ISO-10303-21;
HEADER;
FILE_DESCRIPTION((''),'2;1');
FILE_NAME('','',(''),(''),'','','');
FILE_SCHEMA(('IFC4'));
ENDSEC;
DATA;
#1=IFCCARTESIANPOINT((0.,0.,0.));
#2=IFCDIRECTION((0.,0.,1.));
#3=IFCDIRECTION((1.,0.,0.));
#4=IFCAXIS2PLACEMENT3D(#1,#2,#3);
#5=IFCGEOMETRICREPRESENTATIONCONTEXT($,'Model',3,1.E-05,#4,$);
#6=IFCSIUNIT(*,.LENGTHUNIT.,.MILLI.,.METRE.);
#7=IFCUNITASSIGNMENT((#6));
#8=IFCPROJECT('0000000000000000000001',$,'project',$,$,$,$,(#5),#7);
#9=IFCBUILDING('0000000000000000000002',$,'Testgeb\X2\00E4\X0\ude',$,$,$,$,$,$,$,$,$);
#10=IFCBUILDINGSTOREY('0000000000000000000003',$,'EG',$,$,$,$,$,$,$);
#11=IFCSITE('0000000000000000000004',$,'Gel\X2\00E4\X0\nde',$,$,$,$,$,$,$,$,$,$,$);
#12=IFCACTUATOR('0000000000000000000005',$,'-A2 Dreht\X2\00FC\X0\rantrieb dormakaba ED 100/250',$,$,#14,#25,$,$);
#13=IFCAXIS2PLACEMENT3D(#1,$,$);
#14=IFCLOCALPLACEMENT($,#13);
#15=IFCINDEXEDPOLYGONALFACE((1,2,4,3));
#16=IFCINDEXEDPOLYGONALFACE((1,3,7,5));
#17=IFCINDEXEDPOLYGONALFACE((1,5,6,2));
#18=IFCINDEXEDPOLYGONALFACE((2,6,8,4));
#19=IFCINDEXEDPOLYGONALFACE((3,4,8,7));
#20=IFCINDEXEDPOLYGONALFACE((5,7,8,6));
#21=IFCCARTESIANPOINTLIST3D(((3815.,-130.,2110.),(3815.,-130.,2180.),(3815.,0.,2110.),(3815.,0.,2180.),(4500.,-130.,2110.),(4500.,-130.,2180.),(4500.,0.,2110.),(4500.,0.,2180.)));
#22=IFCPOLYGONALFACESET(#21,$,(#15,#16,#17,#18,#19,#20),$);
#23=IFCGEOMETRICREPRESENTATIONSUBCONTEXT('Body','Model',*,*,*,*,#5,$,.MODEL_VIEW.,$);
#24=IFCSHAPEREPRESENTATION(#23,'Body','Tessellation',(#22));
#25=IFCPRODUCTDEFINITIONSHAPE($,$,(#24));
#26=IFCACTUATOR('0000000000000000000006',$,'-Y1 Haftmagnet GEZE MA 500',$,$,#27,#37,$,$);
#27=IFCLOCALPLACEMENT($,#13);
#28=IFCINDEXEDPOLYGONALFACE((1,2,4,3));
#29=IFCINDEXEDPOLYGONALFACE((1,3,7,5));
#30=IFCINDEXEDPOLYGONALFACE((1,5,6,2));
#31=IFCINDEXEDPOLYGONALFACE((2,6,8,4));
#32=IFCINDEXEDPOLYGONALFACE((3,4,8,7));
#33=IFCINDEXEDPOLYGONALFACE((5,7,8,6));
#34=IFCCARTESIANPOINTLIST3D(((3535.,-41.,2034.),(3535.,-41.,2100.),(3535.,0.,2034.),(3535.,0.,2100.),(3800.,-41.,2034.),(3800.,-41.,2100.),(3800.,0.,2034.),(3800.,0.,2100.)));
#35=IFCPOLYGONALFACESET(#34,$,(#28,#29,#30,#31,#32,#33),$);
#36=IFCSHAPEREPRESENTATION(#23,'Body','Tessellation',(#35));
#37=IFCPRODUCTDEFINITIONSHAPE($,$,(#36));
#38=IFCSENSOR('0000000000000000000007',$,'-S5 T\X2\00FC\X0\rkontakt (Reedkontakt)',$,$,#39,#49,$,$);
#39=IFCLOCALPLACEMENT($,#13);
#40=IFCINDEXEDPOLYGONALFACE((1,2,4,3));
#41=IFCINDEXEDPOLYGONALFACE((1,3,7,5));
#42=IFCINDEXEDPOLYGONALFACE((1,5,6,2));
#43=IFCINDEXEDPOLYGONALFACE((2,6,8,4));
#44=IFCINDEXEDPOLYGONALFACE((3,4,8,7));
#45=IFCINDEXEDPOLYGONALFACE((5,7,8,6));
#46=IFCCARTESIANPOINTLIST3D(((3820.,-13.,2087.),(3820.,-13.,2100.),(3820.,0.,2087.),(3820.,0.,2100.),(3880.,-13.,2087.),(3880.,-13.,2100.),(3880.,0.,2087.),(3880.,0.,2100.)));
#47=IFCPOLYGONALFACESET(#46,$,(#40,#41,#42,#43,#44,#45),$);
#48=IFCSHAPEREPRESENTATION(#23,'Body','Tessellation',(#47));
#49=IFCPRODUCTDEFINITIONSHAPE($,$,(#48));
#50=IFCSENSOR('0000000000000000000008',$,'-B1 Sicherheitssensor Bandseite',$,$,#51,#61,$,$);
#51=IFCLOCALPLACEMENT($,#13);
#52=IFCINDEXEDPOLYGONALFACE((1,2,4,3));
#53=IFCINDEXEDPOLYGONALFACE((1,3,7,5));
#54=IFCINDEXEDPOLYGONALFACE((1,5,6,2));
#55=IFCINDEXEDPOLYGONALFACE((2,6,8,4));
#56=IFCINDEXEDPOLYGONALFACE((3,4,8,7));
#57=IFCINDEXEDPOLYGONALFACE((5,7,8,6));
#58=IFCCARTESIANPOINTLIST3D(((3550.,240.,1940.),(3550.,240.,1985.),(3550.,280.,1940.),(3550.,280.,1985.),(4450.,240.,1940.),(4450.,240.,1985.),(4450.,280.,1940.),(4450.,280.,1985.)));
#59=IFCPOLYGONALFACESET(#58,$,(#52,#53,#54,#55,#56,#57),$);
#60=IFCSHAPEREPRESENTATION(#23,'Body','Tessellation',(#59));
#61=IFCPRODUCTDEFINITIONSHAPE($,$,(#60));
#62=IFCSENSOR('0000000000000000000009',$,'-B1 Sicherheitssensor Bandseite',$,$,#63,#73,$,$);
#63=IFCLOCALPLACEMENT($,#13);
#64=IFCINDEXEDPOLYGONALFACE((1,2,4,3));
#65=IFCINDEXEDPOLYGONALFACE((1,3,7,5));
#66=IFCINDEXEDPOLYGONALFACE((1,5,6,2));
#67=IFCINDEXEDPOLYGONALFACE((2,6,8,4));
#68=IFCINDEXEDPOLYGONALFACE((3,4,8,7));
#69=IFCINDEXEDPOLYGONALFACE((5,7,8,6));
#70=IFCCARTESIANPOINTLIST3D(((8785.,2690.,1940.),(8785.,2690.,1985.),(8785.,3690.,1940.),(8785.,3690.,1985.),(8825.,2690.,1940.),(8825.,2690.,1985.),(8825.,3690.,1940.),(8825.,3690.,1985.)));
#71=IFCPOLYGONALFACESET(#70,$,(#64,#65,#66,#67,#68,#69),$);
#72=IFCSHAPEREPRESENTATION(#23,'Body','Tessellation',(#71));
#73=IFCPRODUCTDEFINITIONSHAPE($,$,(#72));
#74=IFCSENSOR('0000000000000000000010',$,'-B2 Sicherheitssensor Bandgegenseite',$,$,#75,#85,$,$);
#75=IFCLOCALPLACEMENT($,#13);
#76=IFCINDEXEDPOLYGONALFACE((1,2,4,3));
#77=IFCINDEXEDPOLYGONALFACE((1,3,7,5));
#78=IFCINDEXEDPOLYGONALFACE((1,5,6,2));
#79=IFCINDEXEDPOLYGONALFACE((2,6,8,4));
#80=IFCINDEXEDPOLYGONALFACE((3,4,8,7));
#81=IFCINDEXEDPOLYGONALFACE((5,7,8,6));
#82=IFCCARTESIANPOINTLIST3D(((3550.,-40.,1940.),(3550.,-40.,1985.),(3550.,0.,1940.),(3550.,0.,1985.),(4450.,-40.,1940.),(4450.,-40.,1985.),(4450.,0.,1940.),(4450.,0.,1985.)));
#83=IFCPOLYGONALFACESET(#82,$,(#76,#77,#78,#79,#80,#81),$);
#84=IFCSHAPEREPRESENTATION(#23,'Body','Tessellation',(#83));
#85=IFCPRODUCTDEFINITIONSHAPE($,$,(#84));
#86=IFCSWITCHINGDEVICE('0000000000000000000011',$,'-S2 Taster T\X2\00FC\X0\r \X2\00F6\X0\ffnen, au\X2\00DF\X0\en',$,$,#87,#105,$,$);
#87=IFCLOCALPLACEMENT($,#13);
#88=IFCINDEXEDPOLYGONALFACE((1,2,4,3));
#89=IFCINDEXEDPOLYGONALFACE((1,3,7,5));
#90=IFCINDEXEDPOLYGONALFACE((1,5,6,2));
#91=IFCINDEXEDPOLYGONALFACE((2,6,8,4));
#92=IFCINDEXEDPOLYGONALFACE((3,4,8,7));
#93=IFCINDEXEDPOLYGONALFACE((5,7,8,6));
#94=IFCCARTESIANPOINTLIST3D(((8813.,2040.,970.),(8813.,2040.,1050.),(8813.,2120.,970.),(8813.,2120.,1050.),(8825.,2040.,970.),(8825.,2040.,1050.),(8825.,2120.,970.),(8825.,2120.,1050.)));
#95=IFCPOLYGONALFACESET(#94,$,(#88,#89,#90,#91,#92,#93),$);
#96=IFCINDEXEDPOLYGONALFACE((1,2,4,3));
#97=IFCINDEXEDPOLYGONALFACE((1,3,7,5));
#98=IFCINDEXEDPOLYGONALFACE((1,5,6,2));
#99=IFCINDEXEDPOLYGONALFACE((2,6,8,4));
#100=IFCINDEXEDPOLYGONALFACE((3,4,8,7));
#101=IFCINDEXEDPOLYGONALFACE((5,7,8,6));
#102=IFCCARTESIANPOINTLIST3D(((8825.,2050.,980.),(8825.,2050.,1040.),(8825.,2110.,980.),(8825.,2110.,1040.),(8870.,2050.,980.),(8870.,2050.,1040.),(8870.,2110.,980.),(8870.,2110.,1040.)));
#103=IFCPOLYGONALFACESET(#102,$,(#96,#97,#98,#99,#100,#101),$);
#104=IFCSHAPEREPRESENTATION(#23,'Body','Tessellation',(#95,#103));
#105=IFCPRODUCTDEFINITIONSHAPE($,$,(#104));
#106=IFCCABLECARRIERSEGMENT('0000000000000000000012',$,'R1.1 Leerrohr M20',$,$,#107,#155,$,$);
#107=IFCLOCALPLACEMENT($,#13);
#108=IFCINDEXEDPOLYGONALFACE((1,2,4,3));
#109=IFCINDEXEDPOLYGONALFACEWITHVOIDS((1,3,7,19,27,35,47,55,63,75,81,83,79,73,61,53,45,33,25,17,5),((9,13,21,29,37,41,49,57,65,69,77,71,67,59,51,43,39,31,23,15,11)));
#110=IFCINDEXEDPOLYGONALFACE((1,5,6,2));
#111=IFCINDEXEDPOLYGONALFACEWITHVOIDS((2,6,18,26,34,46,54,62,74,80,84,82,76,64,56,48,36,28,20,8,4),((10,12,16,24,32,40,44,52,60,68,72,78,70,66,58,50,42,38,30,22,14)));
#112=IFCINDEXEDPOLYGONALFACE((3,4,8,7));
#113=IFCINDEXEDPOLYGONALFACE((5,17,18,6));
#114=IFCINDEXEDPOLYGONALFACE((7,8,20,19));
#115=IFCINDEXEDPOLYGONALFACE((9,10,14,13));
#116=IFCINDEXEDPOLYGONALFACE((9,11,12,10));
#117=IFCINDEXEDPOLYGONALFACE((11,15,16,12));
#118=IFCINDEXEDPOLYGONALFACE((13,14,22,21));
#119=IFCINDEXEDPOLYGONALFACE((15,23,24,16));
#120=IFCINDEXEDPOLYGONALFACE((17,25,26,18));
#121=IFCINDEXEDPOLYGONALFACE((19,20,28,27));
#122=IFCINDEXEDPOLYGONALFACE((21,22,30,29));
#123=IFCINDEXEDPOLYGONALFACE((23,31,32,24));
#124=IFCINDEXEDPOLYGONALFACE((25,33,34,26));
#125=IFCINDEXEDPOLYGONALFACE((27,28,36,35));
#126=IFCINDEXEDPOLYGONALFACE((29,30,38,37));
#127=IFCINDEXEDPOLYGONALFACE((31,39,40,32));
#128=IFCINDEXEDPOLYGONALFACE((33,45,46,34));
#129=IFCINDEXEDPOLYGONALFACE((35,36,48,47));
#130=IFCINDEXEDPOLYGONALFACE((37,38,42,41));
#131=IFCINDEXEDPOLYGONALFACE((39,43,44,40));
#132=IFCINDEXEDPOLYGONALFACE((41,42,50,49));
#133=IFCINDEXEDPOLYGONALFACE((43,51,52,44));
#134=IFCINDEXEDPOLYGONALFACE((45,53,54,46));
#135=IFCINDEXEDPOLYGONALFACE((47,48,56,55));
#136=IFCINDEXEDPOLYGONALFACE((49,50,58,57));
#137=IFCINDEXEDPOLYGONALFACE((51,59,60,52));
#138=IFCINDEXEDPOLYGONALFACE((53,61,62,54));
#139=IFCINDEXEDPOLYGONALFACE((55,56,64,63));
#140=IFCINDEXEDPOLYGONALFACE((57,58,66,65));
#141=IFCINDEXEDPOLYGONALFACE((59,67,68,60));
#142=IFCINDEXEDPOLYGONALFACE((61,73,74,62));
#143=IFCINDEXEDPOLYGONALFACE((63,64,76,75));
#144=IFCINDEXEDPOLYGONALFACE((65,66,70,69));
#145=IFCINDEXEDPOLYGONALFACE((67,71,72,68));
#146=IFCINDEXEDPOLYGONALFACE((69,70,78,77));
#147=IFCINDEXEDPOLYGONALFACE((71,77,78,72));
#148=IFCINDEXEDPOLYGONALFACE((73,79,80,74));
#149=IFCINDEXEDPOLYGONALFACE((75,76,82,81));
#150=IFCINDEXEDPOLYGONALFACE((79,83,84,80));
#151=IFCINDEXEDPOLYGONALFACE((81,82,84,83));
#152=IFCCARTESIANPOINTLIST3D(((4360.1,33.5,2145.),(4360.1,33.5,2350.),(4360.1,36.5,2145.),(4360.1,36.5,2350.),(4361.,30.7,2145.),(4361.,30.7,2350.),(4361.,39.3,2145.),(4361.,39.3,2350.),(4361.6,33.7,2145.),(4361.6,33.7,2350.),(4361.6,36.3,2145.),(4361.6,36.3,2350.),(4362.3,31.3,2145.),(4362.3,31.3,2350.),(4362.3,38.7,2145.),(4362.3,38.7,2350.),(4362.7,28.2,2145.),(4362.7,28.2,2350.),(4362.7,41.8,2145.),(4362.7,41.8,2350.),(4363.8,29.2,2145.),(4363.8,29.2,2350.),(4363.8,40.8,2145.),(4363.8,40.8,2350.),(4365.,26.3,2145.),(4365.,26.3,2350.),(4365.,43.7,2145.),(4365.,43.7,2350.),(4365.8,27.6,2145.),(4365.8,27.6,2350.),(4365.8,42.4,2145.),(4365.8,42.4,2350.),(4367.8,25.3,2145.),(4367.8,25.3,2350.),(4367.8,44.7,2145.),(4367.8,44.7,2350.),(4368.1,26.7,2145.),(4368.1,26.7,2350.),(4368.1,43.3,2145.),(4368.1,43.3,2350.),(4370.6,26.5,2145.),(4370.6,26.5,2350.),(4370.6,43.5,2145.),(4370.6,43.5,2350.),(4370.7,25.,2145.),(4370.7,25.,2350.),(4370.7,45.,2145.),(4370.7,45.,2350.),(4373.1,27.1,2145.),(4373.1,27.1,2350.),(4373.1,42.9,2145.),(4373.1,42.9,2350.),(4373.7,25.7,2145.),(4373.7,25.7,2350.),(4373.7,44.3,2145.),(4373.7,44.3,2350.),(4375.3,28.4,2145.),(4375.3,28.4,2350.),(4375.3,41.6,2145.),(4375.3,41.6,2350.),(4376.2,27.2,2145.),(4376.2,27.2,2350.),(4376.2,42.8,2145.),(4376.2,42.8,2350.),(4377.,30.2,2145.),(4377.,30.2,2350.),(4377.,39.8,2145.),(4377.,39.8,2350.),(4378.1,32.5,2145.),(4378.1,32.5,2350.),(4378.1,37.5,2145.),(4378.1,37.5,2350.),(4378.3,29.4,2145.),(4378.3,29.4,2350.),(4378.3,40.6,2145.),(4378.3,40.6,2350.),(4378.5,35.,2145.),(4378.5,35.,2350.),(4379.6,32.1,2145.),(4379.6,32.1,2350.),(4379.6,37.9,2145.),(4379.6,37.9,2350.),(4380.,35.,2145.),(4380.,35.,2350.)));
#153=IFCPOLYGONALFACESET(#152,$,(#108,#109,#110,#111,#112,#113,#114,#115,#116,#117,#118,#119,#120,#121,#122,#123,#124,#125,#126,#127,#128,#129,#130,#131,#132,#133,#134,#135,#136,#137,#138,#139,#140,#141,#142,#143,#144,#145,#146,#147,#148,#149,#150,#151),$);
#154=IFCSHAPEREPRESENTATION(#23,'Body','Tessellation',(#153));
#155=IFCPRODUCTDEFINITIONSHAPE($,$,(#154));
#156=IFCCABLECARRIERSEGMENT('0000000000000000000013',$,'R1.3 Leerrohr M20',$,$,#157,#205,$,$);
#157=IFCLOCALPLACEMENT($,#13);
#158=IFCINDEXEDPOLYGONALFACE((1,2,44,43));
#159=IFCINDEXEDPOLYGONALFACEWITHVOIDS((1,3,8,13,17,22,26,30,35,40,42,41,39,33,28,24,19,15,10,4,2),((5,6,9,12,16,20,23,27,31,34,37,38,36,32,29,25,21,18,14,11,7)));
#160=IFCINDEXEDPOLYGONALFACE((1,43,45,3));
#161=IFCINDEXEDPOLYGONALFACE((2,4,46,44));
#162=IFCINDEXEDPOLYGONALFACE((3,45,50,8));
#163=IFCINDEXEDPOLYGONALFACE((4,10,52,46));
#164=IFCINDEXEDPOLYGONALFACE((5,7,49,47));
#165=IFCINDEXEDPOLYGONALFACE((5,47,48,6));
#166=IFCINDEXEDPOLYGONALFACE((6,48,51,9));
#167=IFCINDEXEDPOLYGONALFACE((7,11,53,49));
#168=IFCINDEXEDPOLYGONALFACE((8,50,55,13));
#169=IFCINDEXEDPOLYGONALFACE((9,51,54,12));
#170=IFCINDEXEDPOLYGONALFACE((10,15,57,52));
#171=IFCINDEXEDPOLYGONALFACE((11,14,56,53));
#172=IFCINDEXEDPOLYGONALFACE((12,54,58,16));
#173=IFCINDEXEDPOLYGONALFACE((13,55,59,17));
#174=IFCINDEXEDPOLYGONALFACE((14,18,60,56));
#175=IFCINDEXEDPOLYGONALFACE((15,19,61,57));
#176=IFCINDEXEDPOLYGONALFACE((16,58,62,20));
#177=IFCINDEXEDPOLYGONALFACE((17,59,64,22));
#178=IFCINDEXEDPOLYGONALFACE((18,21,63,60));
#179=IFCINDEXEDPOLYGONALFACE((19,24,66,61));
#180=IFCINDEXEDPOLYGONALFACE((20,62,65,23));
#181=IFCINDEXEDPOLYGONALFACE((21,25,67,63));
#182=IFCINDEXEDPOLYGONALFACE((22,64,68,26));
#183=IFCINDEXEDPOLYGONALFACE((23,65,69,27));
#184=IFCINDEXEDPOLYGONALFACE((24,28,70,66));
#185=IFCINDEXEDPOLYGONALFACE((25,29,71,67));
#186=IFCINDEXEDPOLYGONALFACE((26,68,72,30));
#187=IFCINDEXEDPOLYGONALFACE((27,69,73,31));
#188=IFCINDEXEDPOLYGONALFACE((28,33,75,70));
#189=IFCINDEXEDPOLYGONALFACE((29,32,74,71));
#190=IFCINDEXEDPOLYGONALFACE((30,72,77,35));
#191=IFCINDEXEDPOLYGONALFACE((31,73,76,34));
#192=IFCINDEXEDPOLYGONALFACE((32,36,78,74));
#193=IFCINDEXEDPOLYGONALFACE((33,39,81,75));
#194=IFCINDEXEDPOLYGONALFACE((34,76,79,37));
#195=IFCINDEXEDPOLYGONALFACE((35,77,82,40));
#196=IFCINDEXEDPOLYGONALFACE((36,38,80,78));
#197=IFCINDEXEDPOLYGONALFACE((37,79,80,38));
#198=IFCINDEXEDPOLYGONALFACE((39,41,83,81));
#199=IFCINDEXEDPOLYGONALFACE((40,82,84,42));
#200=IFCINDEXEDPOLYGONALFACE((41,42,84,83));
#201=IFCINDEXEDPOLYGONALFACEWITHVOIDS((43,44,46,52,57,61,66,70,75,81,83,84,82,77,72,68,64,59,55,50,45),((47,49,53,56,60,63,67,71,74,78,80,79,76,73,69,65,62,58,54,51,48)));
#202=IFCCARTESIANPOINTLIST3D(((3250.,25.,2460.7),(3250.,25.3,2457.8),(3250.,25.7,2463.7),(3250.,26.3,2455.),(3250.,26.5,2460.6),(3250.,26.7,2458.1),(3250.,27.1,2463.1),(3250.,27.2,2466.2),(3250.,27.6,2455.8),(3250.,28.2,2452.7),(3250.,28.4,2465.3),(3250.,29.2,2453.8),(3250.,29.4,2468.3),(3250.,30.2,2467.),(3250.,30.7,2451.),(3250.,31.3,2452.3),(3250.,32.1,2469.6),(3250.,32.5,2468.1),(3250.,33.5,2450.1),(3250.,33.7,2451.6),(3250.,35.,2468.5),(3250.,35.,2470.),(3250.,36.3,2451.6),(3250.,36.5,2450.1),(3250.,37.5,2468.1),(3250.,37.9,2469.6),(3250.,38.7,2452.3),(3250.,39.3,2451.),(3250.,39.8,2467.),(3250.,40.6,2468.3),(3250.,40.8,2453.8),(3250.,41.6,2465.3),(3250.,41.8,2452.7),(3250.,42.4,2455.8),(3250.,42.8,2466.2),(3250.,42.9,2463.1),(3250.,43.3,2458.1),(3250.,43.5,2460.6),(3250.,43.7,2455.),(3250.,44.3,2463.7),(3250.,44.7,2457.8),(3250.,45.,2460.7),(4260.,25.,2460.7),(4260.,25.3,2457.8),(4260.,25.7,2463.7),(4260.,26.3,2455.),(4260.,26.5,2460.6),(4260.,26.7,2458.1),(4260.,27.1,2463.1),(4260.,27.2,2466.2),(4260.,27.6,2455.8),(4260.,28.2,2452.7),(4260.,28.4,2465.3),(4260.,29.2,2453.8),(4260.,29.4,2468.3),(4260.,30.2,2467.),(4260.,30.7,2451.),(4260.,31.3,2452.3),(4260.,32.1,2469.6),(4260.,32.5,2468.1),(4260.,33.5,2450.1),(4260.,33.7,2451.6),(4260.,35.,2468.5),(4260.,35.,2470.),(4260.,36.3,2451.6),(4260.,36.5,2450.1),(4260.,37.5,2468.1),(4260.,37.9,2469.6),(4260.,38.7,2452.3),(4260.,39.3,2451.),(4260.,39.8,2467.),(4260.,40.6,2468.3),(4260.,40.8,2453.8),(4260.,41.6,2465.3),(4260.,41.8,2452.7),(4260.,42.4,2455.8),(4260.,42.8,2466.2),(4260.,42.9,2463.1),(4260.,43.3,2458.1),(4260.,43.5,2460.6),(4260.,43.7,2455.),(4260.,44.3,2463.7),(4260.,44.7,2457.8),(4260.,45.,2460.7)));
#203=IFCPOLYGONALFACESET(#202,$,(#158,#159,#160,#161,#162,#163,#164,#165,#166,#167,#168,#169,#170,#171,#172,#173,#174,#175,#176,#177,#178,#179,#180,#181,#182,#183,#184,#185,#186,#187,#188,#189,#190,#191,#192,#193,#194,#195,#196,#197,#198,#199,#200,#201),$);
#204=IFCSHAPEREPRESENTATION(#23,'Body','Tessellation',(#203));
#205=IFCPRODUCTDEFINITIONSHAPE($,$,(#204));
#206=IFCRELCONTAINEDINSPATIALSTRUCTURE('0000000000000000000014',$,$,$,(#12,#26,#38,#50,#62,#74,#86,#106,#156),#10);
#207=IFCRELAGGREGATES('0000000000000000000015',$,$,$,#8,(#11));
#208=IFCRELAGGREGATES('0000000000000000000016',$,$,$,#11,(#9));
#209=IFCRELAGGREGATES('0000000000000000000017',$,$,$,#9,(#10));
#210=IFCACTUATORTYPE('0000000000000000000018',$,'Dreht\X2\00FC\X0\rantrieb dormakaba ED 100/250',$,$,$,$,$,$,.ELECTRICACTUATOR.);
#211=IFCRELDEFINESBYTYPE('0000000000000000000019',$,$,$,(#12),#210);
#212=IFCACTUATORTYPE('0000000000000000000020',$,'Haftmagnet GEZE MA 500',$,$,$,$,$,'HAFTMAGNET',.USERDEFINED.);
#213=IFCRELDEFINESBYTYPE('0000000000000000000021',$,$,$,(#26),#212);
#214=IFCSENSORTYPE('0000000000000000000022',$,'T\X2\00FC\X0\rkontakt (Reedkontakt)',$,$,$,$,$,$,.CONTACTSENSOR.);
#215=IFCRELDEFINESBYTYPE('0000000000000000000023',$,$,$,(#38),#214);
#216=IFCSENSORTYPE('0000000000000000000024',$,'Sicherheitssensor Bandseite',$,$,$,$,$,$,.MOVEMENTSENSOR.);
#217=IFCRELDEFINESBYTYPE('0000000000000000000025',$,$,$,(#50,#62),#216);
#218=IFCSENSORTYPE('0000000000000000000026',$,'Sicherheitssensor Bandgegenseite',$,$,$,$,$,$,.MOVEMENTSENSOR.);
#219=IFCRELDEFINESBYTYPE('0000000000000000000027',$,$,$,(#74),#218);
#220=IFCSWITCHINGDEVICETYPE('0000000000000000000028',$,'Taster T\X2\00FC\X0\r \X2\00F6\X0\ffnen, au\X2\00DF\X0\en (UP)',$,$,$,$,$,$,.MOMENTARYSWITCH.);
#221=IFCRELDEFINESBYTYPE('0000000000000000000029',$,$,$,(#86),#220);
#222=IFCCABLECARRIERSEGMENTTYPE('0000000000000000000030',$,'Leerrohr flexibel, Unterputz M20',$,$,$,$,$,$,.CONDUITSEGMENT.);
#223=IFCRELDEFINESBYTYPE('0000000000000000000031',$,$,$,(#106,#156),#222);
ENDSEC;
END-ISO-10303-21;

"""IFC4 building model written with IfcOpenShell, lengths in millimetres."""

from ifc_helpers import new_model, si_unit, frame, frame_2d, origin_with_axes, place, context, subcontext, project, spatial, rectangle, hollow_circle, extrude, type_object, element, save


model = new_model("IFC4")

# Units and contexts
model_context = context("Model", 3, precision=1e-05, world=origin_with_axes())
body_context = subcontext(model_context, "Body", "Model", "MODEL_VIEW")
ifc_project = project(units=[si_unit("LENGTHUNIT", "METRE", prefix="MILLI")], contexts=[model_context])

# Site, building, storey
site = spatial("IfcSite", under=ifc_project, Name="Gelände")
building = spatial("IfcBuilding", under=site, Name="Testgebäude")
storey = spatial("IfcBuildingStorey", under=building, Name="EG")

# Actuators
actuator_type_1 = type_object("IfcActuatorType", Name="Drehtürantrieb dormakaba ED 100/250", PredefinedType="ELECTRICACTUATOR")
actuator_1_placement = place(None, frame((3815.0, -130.0, 2110.0), z_axis=(0.0, 0.0, 1.0), x_axis=(1.0, 0.0, 0.0)))
element("IfcActuator", 1, at=actuator_1_placement, inside=storey, type_object=actuator_type_1, Name="-A2 Drehtürantrieb dormakaba ED 100/250", context=body_context, shape_type="SweptSolid", body=[
    extrude(rectangle(XDim=685.0, YDim=130.0, at=frame_2d((342.5, 65.0))), None, (0.0, 0.0, 1.0), 70.0),
])
actuator_type_2 = type_object("IfcActuatorType", Name="Haftmagnet GEZE MA 500", ElementType="HAFTMAGNET", PredefinedType="USERDEFINED")
actuator_2_placement = place(None, frame((3535.0, -41.0, 2034.0), z_axis=(0.0, 0.0, 1.0), x_axis=(1.0, 0.0, 0.0)))
element("IfcActuator", 2, at=actuator_2_placement, inside=storey, type_object=actuator_type_2, Name="-Y1 Haftmagnet GEZE MA 500", context=body_context, shape_type="SweptSolid", body=[
    extrude(rectangle(XDim=265.0, YDim=41.0, at=frame_2d((132.5, 20.5))), None, (0.0, 0.0, 1.0), 66.0),
])

# Sensors
sensor_type_1 = type_object("IfcSensorType", Name="Türkontakt (Reedkontakt)", PredefinedType="CONTACTSENSOR")
sensor_1_placement = place(None, frame((3820.0, -13.0, 2087.0), z_axis=(0.0, 0.0, 1.0), x_axis=(1.0, 0.0, 0.0)))
element("IfcSensor", 3, at=sensor_1_placement, inside=storey, type_object=sensor_type_1, Name="-S5 Türkontakt (Reedkontakt)", context=body_context, shape_type="SweptSolid", body=[
    extrude(rectangle(XDim=60.0, YDim=13.0, at=frame_2d((30.0, 6.5))), None, (0.0, 0.0, 1.0), 13.0),
])
sensor_type_2 = type_object("IfcSensorType", Name="Sicherheitssensor Bandseite", PredefinedType="MOVEMENTSENSOR")
sensor_2_placement = place(None, frame((3550.0, 240.0, 1940.0), z_axis=(0.0, 0.0, 1.0), x_axis=(1.0, 0.0, 0.0)))
element("IfcSensor", 4, at=sensor_2_placement, inside=storey, type_object=sensor_type_2, Name="-B1 Sicherheitssensor Bandseite", context=body_context, shape_type="SweptSolid", body=[
    extrude(rectangle(XDim=900.0, YDim=40.0, at=frame_2d((450.0, 20.0))), None, (0.0, 0.0, 1.0), 45.0),
])
sensor_3_placement = place(None, frame((8825.0, 2690.0, 1940.0), z_axis=(0.0, 0.0, 1.0), x_axis=(0.0, 1.0, 0.0)))
element("IfcSensor", 5, at=sensor_3_placement, inside=storey, type_object=sensor_type_2, Name="-B1 Sicherheitssensor Bandseite", context=body_context, shape_type="SweptSolid", body=[
    extrude(rectangle(XDim=1000.0, YDim=40.0, at=frame_2d((500.0, 20.0))), None, (0.0, 0.0, 1.0), 45.0),
])
sensor_type_3 = type_object("IfcSensorType", Name="Sicherheitssensor Bandgegenseite", PredefinedType="MOVEMENTSENSOR")
sensor_4_placement = place(None, frame((3550.0, -40.0, 1940.0), z_axis=(0.0, 0.0, 1.0), x_axis=(1.0, 0.0, 0.0)))
element("IfcSensor", 6, at=sensor_4_placement, inside=storey, type_object=sensor_type_3, Name="-B2 Sicherheitssensor Bandgegenseite", context=body_context, shape_type="SweptSolid", body=[
    extrude(rectangle(XDim=900.0, YDim=40.0, at=frame_2d((450.0, 20.0))), None, (0.0, 0.0, 1.0), 45.0),
])

# Switching device
switching_device_type = type_object("IfcSwitchingDeviceType", Name="Taster Tür öffnen, außen (UP)", PredefinedType="MOMENTARYSWITCH")
switching_device_placement = place(None, frame((8825.0, 2040.0, 970.0), z_axis=(0.0, 0.0, 1.0), x_axis=(0.0, 1.0, 0.0)))
element("IfcSwitchingDevice", 7, at=switching_device_placement, inside=storey, type_object=switching_device_type, Name="-S2 Taster Tür öffnen, außen", context=body_context, shape_type="SweptSolid", body=[
    extrude(rectangle(XDim=80.0, YDim=12.0, at=frame_2d((40.0, 6.0))), None, (0.0, 0.0, 1.0), 80.0),
    extrude(rectangle(XDim=60.0, YDim=45.0, at=frame_2d((30.0, 22.5))), frame((10.0, -45.0, 10.0), z_axis=(0.0, 0.0, 1.0), x_axis=(1.0, 0.0, 0.0)), (0.0, 0.0, 1.0), 60.0),
])

# Cable carrier segments
cable_carrier_segment_type_1 = type_object("IfcCableCarrierSegmentType", Name="Leerrohr flexibel, Unterputz M20", PredefinedType="CONDUITSEGMENT")
cable_carrier_segment_1_placement = place(None, frame((4370.0, 35.0, 2145.0), z_axis=(0.0, 0.0, 1.0), x_axis=(1.0, 0.0, 0.0)))
element("IfcCableCarrierSegment", 8, at=cable_carrier_segment_1_placement, inside=storey, type_object=cable_carrier_segment_type_1, Name="R1.1 Leerrohr M20", context=body_context, shape_type="SweptSolid", body=[
    extrude(hollow_circle(Radius=10.0, WallThickness=1.5), None, (0.0, 0.0, 1.0), 205.0),
])
cable_carrier_segment_2_placement = place(None, frame((4260.0, 35.0, 2460.0), z_axis=(-1.0, 0.0, 0.0), x_axis=(0.0, 0.0, 1.0)))
element("IfcCableCarrierSegment", 9, at=cable_carrier_segment_2_placement, inside=storey, type_object=cable_carrier_segment_type_1, Name="R1.3 Leerrohr M20", context=body_context, shape_type="SweptSolid", body=[
    extrude(hollow_circle(Radius=10.0, WallThickness=1.5), None, (0.0, 0.0, 1.0), 1010.0),
])

save(model, "model.ifc")
